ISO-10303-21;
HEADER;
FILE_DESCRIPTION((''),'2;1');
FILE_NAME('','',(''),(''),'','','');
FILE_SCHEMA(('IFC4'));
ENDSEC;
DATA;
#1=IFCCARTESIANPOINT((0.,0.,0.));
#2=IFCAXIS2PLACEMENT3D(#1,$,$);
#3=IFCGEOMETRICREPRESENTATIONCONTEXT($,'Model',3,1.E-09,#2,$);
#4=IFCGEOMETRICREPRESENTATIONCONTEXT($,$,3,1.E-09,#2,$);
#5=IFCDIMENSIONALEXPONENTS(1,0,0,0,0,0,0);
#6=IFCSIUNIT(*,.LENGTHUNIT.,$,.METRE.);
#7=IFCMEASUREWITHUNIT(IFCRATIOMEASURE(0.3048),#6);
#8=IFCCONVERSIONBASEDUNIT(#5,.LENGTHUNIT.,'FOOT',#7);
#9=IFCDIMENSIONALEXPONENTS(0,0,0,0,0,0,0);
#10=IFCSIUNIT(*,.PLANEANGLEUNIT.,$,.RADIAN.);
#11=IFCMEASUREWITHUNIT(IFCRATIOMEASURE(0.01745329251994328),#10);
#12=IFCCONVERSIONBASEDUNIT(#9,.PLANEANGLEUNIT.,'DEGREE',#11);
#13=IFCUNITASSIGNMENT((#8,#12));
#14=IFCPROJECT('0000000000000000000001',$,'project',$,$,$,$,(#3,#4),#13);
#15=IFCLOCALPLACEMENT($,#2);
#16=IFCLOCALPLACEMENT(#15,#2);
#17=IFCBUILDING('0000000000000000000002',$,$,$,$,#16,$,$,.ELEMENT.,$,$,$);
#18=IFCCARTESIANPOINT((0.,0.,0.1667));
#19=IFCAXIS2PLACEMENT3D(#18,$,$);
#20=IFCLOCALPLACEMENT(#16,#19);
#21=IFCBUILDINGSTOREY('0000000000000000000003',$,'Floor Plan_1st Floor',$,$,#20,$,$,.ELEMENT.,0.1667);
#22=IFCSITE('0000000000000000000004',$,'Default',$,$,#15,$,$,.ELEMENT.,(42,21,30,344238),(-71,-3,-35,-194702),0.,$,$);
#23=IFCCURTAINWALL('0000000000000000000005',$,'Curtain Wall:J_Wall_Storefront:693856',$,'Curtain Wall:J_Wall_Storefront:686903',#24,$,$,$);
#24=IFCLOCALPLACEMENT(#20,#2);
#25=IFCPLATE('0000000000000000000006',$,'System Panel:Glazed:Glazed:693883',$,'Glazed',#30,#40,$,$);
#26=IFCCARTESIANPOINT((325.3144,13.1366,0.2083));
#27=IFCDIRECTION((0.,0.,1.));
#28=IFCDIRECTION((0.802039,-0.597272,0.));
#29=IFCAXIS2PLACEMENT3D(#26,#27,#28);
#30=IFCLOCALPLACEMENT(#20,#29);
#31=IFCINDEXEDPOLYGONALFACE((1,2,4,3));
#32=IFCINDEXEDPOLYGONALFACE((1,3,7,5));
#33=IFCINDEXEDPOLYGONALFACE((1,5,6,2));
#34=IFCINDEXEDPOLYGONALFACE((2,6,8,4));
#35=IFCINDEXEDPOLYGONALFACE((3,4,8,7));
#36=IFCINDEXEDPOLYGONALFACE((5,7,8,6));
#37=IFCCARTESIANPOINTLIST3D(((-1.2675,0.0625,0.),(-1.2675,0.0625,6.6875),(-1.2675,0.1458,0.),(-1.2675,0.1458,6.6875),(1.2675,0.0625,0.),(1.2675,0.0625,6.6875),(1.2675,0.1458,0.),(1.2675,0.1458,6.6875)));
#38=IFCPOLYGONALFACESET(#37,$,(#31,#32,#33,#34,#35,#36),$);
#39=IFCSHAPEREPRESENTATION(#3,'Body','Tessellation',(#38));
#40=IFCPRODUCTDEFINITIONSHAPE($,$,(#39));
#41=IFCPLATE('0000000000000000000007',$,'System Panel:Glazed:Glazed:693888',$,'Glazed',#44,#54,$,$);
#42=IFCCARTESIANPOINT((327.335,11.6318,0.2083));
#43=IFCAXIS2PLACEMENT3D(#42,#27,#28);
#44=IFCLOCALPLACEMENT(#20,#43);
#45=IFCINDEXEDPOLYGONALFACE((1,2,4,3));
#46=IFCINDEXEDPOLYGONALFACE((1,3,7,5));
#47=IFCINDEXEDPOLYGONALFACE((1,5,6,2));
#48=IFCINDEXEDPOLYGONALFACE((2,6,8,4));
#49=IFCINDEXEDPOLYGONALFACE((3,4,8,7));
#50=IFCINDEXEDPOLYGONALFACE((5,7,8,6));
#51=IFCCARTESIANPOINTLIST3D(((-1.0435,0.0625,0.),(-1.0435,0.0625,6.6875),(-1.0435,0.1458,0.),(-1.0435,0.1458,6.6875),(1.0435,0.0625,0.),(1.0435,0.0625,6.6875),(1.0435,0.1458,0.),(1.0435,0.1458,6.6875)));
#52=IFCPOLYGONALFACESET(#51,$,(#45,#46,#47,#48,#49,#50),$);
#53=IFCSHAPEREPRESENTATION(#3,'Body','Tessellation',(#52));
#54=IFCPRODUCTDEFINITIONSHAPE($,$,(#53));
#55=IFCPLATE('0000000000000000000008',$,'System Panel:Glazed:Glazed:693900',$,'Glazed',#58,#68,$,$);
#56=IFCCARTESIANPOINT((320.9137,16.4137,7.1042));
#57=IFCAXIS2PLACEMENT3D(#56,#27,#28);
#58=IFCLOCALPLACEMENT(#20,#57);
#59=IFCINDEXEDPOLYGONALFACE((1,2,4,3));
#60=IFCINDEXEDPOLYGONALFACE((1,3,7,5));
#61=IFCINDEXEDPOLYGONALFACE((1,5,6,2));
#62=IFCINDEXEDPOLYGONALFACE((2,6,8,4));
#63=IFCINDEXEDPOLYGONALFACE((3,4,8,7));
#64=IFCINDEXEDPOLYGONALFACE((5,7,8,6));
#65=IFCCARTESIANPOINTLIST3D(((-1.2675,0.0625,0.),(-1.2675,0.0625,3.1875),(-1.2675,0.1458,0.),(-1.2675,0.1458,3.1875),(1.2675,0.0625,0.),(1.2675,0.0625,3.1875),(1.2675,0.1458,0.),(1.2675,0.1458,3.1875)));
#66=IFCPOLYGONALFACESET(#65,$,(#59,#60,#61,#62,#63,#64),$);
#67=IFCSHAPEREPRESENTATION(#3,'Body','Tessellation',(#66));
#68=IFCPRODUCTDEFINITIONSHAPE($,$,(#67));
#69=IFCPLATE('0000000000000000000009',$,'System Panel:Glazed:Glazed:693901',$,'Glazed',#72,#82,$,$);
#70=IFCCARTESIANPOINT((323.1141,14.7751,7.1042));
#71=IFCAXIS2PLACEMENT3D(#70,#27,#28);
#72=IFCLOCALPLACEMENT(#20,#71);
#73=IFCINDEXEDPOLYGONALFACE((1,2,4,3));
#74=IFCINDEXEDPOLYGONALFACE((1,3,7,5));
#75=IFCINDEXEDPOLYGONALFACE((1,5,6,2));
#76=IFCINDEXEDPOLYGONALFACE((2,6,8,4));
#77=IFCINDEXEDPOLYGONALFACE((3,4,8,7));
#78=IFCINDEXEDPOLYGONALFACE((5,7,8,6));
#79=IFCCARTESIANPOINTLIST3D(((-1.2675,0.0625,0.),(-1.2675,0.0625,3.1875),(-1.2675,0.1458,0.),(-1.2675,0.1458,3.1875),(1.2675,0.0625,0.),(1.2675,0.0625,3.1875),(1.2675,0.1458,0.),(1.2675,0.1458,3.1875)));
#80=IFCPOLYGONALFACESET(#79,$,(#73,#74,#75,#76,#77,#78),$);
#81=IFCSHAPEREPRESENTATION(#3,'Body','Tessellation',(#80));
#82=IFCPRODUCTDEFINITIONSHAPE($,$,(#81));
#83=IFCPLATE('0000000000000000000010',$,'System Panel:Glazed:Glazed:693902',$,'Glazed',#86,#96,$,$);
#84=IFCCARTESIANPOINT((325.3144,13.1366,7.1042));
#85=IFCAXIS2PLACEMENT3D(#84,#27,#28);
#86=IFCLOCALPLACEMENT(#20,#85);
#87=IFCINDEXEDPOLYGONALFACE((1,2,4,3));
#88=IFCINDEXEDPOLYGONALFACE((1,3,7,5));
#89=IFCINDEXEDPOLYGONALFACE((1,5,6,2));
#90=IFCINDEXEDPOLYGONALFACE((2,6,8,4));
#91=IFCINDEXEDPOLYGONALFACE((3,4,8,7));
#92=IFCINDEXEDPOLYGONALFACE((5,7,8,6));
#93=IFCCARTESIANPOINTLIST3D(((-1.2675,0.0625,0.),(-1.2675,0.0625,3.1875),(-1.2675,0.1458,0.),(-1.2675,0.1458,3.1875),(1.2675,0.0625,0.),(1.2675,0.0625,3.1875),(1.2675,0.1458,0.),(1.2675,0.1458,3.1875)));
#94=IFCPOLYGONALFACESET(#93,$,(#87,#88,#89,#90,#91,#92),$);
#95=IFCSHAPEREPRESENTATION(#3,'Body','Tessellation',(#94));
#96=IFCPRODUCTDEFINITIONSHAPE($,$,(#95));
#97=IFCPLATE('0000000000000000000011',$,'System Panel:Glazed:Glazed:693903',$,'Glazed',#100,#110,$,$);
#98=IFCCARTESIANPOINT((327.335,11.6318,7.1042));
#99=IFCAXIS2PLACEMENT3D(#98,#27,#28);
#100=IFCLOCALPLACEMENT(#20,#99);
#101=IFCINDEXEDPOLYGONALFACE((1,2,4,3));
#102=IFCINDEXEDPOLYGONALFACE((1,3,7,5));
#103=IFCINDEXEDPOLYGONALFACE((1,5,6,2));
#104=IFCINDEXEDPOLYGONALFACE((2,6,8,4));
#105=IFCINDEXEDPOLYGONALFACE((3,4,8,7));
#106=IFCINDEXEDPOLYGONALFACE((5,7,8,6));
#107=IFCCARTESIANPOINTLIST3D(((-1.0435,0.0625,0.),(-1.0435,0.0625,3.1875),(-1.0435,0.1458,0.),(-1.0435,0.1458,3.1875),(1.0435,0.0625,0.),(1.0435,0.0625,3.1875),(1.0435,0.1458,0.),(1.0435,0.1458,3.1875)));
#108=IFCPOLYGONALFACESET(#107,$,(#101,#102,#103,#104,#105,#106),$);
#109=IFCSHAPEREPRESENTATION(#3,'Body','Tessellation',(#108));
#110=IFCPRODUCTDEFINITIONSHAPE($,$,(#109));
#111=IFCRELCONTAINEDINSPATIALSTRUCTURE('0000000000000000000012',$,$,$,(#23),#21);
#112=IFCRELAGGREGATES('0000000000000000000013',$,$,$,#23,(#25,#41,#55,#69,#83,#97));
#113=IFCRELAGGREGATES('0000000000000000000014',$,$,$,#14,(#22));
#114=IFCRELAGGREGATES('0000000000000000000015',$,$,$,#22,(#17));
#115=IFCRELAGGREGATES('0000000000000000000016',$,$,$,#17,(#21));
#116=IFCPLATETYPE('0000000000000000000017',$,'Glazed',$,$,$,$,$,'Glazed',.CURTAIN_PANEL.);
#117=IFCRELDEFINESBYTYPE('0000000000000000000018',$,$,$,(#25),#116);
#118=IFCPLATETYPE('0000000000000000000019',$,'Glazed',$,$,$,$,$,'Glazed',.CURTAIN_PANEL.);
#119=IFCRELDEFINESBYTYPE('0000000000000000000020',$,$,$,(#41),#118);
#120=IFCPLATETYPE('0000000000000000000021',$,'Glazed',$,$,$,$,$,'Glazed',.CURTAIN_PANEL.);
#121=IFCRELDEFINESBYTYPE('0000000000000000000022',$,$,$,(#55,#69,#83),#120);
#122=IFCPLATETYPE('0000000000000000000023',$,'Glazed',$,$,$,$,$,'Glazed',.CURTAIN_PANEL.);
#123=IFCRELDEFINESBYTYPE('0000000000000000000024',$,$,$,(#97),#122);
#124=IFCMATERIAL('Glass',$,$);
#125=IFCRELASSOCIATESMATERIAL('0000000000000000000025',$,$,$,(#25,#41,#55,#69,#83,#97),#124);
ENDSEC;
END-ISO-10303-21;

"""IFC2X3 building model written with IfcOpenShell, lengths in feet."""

from ifc_helpers import new_model, entity, si_unit, converted_unit, frame, origin, origin_2d_with_axis, place, context, project, spatial, rectangle, extrude, source, transform, mapped, material, type_object, type_shapes, element, aggregate, save


model = new_model("IFC2X3")

# Units and contexts
model_context = context("Model", 3, precision=1e-09, world=origin())
context_of_model = context(None, 3, precision=1e-09, world=origin())
ifc_project = project(units=[converted_unit("LENGTHUNIT", "FOOT", entity("IfcRatioMeasure", 0.3048), si_unit("LENGTHUNIT", "METRE"), dimensions=[1, 0, 0, 0, 0, 0, 0]), converted_unit("PLANEANGLEUNIT", "DEGREE", entity("IfcRatioMeasure", 0.01745329251994328), si_unit("PLANEANGLEUNIT", "RADIAN"), dimensions=[0, 0, 0, 0, 0, 0, 0])], contexts=[model_context, context_of_model])

# Site, building, storey
site_placement = place(None, origin())
site = spatial("IfcSite", under=ifc_project, at=site_placement, Name="Default", CompositionType="ELEMENT", RefLatitude=(42, 21, 30, 344238), RefLongitude=(-71, -3, -35, -194702), RefElevation=0.0)
building_placement = place(site_placement, origin())
building = spatial("IfcBuilding", under=site, at=building_placement, CompositionType="ELEMENT")
storey_placement = place(building_placement, frame((0.0, 0.0, 0.1667)))
storey = spatial("IfcBuildingStorey", under=building, at=storey_placement, Name="Floor Plan_1st Floor", CompositionType="ELEMENT", Elevation=0.1667)

# Curtain wall, plates
curtain_wall_placement = place(storey_placement, origin())
curtain_wall = element("IfcCurtainWall", 1, at=curtain_wall_placement, inside=storey, Name="Curtain Wall:J_Wall_Storefront:693856", ObjectType="Curtain Wall:J_Wall_Storefront:686903")
ifc_material_1 = material(Name="Glass")
plate_type_1 = type_object("IfcPlateType", Name="Glazed", ElementType="Glazed", PredefinedType="CURTAIN_PANEL")
shared_shape_1 = source(origin(), model_context, "Body", "SweptSolid", [
    extrude(rectangle(XDim=0.0833, YDim=2.5351, at=origin_2d_with_axis()), frame((0.0, 0.1042, 0.0), z_axis=(0.0, 0.0, 1.0), x_axis=(0.0, 1.0, 0.0)), (0.0, 0.0, 1.0), 6.6875),
])
type_shapes(plate_type_1, [shared_shape_1])
plate_1_placement = place(storey_placement, frame((325.3144, 13.1366, 0.2083), z_axis=(0.0, 0.0, 1.0), x_axis=(0.802039, -0.597272, 0.0)))
plate_1 = element("IfcPlate", 2, at=plate_1_placement, type_object=plate_type_1, material=ifc_material_1, Name="System Panel:Glazed:Glazed:693883", ObjectType="Glazed", context=model_context, shape_type="MappedRepresentation", body=[
    mapped(shared_shape_1, transform((0.0, 0.0, 0.0), scale=1.0)),
])
plate_type_2 = type_object("IfcPlateType", Name="Glazed", ElementType="Glazed", PredefinedType="CURTAIN_PANEL")
shared_shape_2 = source(origin(), model_context, "Body", "SweptSolid", [
    extrude(rectangle(XDim=0.0833, YDim=2.0869, at=origin_2d_with_axis()), frame((0.0, 0.1042, 0.0), z_axis=(0.0, 0.0, 1.0), x_axis=(0.0, 1.0, 0.0)), (0.0, 0.0, 1.0), 6.6875),
])
type_shapes(plate_type_2, [shared_shape_2])
plate_2_placement = place(storey_placement, frame((327.335, 11.6318, 0.2083), z_axis=(0.0, 0.0, 1.0), x_axis=(0.802039, -0.597272, 0.0)))
plate_2 = element("IfcPlate", 3, at=plate_2_placement, type_object=plate_type_2, material=ifc_material_1, Name="System Panel:Glazed:Glazed:693888", ObjectType="Glazed", context=model_context, shape_type="MappedRepresentation", body=[
    mapped(shared_shape_2, transform((0.0, 0.0, 0.0), scale=1.0)),
])
plate_type_3 = type_object("IfcPlateType", Name="Glazed", ElementType="Glazed", PredefinedType="CURTAIN_PANEL")
shared_shape_3 = source(origin(), model_context, "Body", "SweptSolid", [
    extrude(rectangle(XDim=0.0833, YDim=2.5351, at=origin_2d_with_axis()), frame((0.0, 0.1042, 0.0), z_axis=(0.0, 0.0, 1.0), x_axis=(0.0, 1.0, 0.0)), (0.0, 0.0, 1.0), 3.1875),
])
type_shapes(plate_type_3, [shared_shape_3])
plate_3_placement = place(storey_placement, frame((320.9137, 16.4137, 7.1042), z_axis=(0.0, 0.0, 1.0), x_axis=(0.802039, -0.597272, 0.0)))
plate_3 = element("IfcPlate", 4, at=plate_3_placement, type_object=plate_type_3, material=ifc_material_1, Name="System Panel:Glazed:Glazed:693900", ObjectType="Glazed", context=model_context, shape_type="MappedRepresentation", body=[
    mapped(shared_shape_3, transform((0.0, 0.0, 0.0), scale=1.0)),
])
plate_4_placement = place(storey_placement, frame((323.1141, 14.7751, 7.1042), z_axis=(0.0, 0.0, 1.0), x_axis=(0.802039, -0.597272, 0.0)))
plate_4 = element("IfcPlate", 5, at=plate_4_placement, type_object=plate_type_3, material=ifc_material_1, Name="System Panel:Glazed:Glazed:693901", ObjectType="Glazed", context=model_context, shape_type="MappedRepresentation", body=[
    mapped(shared_shape_3, transform((0.0, 0.0, 0.0), scale=1.0)),
])
plate_5_placement = place(storey_placement, frame((325.3144, 13.1366, 7.1042), z_axis=(0.0, 0.0, 1.0), x_axis=(0.802039, -0.597272, 0.0)))
plate_5 = element("IfcPlate", 6, at=plate_5_placement, type_object=plate_type_3, material=ifc_material_1, Name="System Panel:Glazed:Glazed:693902", ObjectType="Glazed", context=model_context, shape_type="MappedRepresentation", body=[
    mapped(shared_shape_3, transform((0.0, 0.0, 0.0), scale=1.0)),
])
plate_type_4 = type_object("IfcPlateType", Name="Glazed", ElementType="Glazed", PredefinedType="CURTAIN_PANEL")
shared_shape_4 = source(origin(), model_context, "Body", "SweptSolid", [
    extrude(rectangle(XDim=0.0833, YDim=2.0869, at=origin_2d_with_axis()), frame((0.0, 0.1042, 0.0), z_axis=(0.0, 0.0, 1.0), x_axis=(0.0, 1.0, 0.0)), (0.0, 0.0, 1.0), 3.1875),
])
type_shapes(plate_type_4, [shared_shape_4])
plate_6_placement = place(storey_placement, frame((327.335, 11.6318, 7.1042), z_axis=(0.0, 0.0, 1.0), x_axis=(0.802039, -0.597272, 0.0)))
plate_6 = element("IfcPlate", 7, at=plate_6_placement, type_object=plate_type_4, material=ifc_material_1, Name="System Panel:Glazed:Glazed:693903", ObjectType="Glazed", context=model_context, shape_type="MappedRepresentation", body=[
    mapped(shared_shape_4, transform((0.0, 0.0, 0.0), scale=1.0)),
])
aggregate(curtain_wall, [plate_1, plate_2, plate_3, plate_4, plate_5, plate_6])

save(model, "model.ifc")
